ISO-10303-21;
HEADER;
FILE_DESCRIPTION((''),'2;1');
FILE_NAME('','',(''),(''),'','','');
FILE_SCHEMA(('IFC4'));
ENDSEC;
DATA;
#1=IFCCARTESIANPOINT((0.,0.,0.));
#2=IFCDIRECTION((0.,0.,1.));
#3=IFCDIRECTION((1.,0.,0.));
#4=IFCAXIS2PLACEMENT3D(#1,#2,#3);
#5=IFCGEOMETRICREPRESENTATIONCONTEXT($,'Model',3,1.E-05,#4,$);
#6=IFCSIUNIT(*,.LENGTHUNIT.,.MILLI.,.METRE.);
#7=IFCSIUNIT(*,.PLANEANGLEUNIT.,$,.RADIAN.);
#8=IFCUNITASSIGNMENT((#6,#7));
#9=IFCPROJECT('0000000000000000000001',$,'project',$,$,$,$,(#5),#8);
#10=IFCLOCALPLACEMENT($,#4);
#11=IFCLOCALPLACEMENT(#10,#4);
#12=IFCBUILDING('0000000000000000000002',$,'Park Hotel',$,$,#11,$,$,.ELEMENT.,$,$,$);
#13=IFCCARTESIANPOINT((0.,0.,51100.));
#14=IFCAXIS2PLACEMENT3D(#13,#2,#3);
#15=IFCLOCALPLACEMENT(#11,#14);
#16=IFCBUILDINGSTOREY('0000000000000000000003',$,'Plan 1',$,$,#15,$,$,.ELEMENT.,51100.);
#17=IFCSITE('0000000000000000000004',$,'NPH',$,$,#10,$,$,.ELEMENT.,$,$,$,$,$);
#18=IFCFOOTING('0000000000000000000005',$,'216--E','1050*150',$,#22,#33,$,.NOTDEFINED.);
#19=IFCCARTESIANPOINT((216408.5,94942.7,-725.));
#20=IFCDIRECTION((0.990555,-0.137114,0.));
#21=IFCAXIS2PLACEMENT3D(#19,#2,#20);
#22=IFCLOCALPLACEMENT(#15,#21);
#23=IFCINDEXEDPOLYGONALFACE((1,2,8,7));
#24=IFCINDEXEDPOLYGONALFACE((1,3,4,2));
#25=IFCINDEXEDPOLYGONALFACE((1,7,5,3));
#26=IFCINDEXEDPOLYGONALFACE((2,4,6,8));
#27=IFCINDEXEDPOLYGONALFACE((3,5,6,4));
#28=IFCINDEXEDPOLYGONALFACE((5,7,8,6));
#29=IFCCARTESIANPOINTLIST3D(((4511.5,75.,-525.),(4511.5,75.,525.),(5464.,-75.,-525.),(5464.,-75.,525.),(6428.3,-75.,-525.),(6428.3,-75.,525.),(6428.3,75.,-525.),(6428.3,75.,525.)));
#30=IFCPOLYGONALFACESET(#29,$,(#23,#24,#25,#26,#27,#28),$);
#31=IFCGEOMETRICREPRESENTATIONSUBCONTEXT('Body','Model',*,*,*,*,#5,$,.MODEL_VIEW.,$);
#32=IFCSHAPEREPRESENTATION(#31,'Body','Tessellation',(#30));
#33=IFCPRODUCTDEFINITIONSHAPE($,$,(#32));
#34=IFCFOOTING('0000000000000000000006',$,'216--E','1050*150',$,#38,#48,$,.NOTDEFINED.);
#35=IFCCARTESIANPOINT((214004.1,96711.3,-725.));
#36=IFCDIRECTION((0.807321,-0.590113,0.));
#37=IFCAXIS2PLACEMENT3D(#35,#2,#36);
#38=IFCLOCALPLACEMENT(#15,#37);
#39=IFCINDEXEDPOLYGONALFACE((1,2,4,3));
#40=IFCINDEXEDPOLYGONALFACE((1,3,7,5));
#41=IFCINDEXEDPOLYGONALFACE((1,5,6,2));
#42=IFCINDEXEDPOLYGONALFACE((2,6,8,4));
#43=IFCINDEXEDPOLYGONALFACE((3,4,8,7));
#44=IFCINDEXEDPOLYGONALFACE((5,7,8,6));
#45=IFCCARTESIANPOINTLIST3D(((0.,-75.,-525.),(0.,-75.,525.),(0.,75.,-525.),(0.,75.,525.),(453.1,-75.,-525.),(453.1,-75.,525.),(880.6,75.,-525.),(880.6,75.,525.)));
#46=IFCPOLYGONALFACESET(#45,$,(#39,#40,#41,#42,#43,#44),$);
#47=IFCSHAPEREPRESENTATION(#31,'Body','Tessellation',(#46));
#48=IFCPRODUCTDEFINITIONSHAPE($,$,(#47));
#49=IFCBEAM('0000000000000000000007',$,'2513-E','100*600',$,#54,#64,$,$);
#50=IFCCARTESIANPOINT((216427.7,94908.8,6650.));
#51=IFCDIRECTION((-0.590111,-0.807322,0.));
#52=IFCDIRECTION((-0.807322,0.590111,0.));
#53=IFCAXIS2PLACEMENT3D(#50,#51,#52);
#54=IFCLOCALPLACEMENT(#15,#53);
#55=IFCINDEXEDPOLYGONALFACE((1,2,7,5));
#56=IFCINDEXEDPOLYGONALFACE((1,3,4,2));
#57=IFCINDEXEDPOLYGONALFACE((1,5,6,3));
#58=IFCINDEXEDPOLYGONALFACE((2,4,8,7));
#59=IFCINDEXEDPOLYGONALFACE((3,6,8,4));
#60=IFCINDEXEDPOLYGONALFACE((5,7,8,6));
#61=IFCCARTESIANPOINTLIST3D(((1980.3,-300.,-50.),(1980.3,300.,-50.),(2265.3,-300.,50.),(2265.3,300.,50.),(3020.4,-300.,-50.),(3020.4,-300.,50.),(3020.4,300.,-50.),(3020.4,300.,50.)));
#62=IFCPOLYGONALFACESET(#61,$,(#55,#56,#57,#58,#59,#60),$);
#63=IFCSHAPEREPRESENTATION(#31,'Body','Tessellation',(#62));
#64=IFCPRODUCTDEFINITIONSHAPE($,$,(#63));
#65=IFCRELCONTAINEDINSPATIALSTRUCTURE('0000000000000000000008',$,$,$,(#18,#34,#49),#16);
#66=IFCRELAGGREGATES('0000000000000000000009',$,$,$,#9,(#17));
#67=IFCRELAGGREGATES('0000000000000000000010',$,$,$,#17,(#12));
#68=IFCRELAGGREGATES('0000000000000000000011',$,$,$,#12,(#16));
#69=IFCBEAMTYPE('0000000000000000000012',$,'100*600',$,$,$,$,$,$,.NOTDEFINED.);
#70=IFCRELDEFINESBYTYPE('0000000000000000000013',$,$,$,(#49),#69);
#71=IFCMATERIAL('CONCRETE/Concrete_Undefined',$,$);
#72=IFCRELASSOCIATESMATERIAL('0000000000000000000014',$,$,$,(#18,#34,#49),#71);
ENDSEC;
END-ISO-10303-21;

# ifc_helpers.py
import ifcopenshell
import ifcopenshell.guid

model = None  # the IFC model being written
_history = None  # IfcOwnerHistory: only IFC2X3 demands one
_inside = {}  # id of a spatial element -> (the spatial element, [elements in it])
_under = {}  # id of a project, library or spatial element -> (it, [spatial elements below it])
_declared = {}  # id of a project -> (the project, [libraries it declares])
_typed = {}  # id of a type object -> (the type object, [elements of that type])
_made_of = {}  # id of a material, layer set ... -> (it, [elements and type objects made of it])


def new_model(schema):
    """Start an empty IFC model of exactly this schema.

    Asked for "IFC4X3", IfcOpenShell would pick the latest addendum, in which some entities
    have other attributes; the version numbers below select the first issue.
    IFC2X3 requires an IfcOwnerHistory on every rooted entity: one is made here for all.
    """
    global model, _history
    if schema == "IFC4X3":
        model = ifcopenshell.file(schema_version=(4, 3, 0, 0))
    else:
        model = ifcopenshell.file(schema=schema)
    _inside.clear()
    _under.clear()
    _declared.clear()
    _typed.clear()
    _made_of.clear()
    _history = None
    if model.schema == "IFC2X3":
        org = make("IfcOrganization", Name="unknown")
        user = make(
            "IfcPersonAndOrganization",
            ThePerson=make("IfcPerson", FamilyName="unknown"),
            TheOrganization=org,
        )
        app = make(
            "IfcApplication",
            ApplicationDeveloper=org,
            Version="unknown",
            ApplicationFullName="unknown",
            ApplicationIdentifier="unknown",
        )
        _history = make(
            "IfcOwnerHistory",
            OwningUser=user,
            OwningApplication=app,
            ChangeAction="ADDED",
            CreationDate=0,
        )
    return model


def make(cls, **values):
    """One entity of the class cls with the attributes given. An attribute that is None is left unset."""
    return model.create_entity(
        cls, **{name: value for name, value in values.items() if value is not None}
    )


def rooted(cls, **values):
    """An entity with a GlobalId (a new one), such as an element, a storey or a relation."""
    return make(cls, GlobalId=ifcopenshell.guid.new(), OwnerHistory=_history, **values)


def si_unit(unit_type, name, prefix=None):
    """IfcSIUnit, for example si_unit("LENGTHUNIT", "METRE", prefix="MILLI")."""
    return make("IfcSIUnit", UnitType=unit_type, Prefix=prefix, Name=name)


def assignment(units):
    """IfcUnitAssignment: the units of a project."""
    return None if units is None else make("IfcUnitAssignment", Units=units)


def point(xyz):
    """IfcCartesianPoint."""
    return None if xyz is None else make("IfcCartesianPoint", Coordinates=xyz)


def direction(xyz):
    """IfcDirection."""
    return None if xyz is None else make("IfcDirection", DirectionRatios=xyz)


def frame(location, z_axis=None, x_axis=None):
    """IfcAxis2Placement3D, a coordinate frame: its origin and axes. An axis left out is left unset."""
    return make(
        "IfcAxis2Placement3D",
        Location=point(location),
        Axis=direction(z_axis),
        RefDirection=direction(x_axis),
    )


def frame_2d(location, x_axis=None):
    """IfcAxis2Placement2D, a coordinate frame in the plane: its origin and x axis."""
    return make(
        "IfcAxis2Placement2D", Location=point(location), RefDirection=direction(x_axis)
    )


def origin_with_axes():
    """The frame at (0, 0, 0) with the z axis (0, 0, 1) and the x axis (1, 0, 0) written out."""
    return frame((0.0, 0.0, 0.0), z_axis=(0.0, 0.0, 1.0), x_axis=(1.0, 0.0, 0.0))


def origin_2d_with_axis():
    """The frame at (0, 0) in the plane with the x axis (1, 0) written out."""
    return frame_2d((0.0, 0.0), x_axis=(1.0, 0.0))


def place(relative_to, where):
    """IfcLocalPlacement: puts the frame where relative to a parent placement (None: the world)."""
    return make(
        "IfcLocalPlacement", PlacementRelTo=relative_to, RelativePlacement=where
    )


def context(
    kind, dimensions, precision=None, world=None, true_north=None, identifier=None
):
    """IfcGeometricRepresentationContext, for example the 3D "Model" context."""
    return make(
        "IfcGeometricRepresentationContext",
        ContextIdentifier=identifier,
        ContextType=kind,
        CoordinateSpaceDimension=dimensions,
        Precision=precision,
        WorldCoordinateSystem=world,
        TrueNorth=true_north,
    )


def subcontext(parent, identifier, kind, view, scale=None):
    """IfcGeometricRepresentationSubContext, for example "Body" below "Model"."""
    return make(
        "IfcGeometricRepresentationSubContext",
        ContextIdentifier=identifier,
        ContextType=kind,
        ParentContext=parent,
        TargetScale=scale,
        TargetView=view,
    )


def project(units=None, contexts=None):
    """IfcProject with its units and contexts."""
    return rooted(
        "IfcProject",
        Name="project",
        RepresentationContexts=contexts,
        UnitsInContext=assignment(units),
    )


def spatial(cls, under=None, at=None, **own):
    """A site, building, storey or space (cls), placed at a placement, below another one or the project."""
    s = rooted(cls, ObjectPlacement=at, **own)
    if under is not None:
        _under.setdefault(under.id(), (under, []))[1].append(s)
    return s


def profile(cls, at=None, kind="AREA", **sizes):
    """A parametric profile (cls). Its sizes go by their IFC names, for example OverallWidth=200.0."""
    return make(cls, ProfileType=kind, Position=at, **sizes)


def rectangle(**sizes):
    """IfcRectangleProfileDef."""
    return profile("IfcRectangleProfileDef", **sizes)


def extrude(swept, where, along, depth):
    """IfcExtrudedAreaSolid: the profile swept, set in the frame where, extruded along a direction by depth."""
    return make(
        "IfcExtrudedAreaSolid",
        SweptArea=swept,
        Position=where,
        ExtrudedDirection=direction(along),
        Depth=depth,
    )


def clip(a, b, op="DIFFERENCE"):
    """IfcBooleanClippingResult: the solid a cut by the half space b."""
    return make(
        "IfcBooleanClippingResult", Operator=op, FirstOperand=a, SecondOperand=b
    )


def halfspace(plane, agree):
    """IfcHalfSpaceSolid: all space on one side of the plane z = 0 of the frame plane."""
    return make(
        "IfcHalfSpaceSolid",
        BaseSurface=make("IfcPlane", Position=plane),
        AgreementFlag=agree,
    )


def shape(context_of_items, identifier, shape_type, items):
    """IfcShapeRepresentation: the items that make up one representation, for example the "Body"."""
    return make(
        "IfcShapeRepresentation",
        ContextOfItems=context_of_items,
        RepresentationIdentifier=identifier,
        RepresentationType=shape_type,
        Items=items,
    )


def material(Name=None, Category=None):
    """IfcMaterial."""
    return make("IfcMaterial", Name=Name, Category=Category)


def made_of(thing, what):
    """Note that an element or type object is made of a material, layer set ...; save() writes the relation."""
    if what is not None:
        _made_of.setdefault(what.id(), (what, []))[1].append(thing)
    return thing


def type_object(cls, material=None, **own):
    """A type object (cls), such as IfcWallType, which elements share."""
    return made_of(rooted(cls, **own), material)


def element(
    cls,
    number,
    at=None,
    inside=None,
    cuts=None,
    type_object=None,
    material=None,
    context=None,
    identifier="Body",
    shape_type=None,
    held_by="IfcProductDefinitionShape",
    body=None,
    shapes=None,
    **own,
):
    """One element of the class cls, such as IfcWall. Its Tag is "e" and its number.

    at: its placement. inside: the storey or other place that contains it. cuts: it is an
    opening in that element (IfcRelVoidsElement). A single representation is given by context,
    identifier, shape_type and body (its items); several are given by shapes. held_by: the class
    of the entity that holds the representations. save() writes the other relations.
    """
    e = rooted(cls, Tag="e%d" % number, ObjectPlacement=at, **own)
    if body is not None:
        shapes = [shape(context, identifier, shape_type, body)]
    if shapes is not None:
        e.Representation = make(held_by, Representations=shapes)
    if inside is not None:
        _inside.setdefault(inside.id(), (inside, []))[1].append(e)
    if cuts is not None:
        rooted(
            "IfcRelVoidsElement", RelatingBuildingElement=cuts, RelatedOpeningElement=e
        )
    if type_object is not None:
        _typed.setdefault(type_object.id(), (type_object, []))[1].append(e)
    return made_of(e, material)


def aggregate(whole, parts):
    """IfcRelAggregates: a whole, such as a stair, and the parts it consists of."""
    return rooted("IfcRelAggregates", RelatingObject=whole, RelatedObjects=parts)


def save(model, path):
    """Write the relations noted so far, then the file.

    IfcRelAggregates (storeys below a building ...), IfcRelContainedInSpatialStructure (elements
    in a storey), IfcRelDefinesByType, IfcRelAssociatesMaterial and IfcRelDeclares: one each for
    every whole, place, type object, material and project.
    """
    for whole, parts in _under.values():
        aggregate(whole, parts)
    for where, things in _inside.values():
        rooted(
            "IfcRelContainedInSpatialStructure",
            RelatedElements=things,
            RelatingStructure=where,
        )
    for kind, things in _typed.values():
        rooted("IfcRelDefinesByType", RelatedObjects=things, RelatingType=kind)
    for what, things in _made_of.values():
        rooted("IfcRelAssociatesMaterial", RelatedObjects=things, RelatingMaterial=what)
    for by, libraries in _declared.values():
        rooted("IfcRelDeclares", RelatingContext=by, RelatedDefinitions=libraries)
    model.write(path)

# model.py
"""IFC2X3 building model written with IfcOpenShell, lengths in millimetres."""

from ifc_helpers import new_model, si_unit, frame, origin_with_axes, origin_2d_with_axis, place, context, subcontext, project, spatial, rectangle, extrude, clip, halfspace, material, type_object, element, save


model = new_model("IFC2X3")

# Units and contexts
model_context = context("Model", 3, precision=1e-05, world=origin_with_axes())
body_context = subcontext(model_context, "Body", "Model", "MODEL_VIEW")
ifc_project = project(units=[si_unit("LENGTHUNIT", "METRE", prefix="MILLI"), si_unit("PLANEANGLEUNIT", "RADIAN")], contexts=[model_context])

# Site, building, storey
site_placement = place(None, origin_with_axes())
site = spatial("IfcSite", under=ifc_project, at=site_placement, Name="NPH", CompositionType="ELEMENT")
building_placement = place(site_placement, origin_with_axes())
building = spatial("IfcBuilding", under=site, at=building_placement, Name="Park Hotel", CompositionType="ELEMENT")
storey_placement = place(building_placement, frame((0.0, 0.0, 51100.0), z_axis=(0.0, 0.0, 1.0), x_axis=(1.0, 0.0, 0.0)))
storey = spatial("IfcBuildingStorey", under=building, at=storey_placement, Name="Plan 1", CompositionType="ELEMENT", Elevation=51100.0)

# Footings
ifc_material_1 = material(Name="CONCRETE/Concrete_Undefined")
footing_1_placement = place(storey_placement, frame((216408.5, 94942.7, -725.0), z_axis=(0.0, 0.0, 1.0), x_axis=(0.990555, -0.137114, 0.0)))
element("IfcFooting", 1, at=footing_1_placement, inside=storey, material=ifc_material_1, Name="216--E", Description="1050*150", PredefinedType="NOTDEFINED", context=body_context, shape_type="Clipping", body=[
    clip(extrude(rectangle(XDim=150.0, YDim=1050.0, at=origin_2d_with_axis()), frame((6428.3, 0.0, 0.0), z_axis=(-1.0, 0.0, 0.0), x_axis=(0.0, -1.0, 0.0)), (0.0, 0.0, 1.0), 6428.3), halfspace(frame((4511.5, 75.0, -525.0), z_axis=(-0.155563, -0.987826, 0.0), x_axis=(0.0, 0.0, 1.0)), False)),
])
footing_2_placement = place(storey_placement, frame((214004.1, 96711.3, -725.0), z_axis=(0.0, 0.0, 1.0), x_axis=(0.807321, -0.590113, 0.0)))
element("IfcFooting", 2, at=footing_2_placement, inside=storey, material=ifc_material_1, Name="216--E", Description="1050*150", PredefinedType="NOTDEFINED", context=body_context, shape_type="Clipping", body=[
    clip(extrude(rectangle(XDim=150.0, YDim=1050.0, at=origin_2d_with_axis()), frame((3020.3, 0.0, 0.0), z_axis=(-1.0, 0.0, 0.0), x_axis=(0.0, -1.0, 0.0)), (0.0, 0.0, 1.0), 3020.3), halfspace(frame((453.1, -75.0, -525.0), z_axis=(0.331087, -0.9436, 0.0), x_axis=(0.0, 0.0, 1.0)), False)),
])

# Beam
beam_type_1 = type_object("IfcBeamType", Name="100*600", PredefinedType="NOTDEFINED")
beam_1_placement = place(storey_placement, frame((216427.7, 94908.8, 6650.0), z_axis=(-0.590111, -0.807322, 0.0), x_axis=(-0.807322, 0.590111, 0.0)))
element("IfcBeam", 3, at=beam_1_placement, inside=storey, type_object=beam_type_1, material=ifc_material_1, Name="2513-E", Description="100*600", context=body_context, shape_type="Clipping", body=[
    clip(extrude(rectangle(XDim=600.0, YDim=100.0, at=origin_2d_with_axis()), frame((3020.4, 0.0, 0.0), z_axis=(-1.0, 0.0, 0.0), x_axis=(0.0, -1.0, 0.0)), (0.0, 0.0, 1.0), 3020.3), halfspace(frame((2265.3, -300.0, 50.0), z_axis=(-0.331085, 0.0, 0.943601), x_axis=(-0.943601, 0.0, -0.331085)), False)),
])

save(model, "model.ifc")
